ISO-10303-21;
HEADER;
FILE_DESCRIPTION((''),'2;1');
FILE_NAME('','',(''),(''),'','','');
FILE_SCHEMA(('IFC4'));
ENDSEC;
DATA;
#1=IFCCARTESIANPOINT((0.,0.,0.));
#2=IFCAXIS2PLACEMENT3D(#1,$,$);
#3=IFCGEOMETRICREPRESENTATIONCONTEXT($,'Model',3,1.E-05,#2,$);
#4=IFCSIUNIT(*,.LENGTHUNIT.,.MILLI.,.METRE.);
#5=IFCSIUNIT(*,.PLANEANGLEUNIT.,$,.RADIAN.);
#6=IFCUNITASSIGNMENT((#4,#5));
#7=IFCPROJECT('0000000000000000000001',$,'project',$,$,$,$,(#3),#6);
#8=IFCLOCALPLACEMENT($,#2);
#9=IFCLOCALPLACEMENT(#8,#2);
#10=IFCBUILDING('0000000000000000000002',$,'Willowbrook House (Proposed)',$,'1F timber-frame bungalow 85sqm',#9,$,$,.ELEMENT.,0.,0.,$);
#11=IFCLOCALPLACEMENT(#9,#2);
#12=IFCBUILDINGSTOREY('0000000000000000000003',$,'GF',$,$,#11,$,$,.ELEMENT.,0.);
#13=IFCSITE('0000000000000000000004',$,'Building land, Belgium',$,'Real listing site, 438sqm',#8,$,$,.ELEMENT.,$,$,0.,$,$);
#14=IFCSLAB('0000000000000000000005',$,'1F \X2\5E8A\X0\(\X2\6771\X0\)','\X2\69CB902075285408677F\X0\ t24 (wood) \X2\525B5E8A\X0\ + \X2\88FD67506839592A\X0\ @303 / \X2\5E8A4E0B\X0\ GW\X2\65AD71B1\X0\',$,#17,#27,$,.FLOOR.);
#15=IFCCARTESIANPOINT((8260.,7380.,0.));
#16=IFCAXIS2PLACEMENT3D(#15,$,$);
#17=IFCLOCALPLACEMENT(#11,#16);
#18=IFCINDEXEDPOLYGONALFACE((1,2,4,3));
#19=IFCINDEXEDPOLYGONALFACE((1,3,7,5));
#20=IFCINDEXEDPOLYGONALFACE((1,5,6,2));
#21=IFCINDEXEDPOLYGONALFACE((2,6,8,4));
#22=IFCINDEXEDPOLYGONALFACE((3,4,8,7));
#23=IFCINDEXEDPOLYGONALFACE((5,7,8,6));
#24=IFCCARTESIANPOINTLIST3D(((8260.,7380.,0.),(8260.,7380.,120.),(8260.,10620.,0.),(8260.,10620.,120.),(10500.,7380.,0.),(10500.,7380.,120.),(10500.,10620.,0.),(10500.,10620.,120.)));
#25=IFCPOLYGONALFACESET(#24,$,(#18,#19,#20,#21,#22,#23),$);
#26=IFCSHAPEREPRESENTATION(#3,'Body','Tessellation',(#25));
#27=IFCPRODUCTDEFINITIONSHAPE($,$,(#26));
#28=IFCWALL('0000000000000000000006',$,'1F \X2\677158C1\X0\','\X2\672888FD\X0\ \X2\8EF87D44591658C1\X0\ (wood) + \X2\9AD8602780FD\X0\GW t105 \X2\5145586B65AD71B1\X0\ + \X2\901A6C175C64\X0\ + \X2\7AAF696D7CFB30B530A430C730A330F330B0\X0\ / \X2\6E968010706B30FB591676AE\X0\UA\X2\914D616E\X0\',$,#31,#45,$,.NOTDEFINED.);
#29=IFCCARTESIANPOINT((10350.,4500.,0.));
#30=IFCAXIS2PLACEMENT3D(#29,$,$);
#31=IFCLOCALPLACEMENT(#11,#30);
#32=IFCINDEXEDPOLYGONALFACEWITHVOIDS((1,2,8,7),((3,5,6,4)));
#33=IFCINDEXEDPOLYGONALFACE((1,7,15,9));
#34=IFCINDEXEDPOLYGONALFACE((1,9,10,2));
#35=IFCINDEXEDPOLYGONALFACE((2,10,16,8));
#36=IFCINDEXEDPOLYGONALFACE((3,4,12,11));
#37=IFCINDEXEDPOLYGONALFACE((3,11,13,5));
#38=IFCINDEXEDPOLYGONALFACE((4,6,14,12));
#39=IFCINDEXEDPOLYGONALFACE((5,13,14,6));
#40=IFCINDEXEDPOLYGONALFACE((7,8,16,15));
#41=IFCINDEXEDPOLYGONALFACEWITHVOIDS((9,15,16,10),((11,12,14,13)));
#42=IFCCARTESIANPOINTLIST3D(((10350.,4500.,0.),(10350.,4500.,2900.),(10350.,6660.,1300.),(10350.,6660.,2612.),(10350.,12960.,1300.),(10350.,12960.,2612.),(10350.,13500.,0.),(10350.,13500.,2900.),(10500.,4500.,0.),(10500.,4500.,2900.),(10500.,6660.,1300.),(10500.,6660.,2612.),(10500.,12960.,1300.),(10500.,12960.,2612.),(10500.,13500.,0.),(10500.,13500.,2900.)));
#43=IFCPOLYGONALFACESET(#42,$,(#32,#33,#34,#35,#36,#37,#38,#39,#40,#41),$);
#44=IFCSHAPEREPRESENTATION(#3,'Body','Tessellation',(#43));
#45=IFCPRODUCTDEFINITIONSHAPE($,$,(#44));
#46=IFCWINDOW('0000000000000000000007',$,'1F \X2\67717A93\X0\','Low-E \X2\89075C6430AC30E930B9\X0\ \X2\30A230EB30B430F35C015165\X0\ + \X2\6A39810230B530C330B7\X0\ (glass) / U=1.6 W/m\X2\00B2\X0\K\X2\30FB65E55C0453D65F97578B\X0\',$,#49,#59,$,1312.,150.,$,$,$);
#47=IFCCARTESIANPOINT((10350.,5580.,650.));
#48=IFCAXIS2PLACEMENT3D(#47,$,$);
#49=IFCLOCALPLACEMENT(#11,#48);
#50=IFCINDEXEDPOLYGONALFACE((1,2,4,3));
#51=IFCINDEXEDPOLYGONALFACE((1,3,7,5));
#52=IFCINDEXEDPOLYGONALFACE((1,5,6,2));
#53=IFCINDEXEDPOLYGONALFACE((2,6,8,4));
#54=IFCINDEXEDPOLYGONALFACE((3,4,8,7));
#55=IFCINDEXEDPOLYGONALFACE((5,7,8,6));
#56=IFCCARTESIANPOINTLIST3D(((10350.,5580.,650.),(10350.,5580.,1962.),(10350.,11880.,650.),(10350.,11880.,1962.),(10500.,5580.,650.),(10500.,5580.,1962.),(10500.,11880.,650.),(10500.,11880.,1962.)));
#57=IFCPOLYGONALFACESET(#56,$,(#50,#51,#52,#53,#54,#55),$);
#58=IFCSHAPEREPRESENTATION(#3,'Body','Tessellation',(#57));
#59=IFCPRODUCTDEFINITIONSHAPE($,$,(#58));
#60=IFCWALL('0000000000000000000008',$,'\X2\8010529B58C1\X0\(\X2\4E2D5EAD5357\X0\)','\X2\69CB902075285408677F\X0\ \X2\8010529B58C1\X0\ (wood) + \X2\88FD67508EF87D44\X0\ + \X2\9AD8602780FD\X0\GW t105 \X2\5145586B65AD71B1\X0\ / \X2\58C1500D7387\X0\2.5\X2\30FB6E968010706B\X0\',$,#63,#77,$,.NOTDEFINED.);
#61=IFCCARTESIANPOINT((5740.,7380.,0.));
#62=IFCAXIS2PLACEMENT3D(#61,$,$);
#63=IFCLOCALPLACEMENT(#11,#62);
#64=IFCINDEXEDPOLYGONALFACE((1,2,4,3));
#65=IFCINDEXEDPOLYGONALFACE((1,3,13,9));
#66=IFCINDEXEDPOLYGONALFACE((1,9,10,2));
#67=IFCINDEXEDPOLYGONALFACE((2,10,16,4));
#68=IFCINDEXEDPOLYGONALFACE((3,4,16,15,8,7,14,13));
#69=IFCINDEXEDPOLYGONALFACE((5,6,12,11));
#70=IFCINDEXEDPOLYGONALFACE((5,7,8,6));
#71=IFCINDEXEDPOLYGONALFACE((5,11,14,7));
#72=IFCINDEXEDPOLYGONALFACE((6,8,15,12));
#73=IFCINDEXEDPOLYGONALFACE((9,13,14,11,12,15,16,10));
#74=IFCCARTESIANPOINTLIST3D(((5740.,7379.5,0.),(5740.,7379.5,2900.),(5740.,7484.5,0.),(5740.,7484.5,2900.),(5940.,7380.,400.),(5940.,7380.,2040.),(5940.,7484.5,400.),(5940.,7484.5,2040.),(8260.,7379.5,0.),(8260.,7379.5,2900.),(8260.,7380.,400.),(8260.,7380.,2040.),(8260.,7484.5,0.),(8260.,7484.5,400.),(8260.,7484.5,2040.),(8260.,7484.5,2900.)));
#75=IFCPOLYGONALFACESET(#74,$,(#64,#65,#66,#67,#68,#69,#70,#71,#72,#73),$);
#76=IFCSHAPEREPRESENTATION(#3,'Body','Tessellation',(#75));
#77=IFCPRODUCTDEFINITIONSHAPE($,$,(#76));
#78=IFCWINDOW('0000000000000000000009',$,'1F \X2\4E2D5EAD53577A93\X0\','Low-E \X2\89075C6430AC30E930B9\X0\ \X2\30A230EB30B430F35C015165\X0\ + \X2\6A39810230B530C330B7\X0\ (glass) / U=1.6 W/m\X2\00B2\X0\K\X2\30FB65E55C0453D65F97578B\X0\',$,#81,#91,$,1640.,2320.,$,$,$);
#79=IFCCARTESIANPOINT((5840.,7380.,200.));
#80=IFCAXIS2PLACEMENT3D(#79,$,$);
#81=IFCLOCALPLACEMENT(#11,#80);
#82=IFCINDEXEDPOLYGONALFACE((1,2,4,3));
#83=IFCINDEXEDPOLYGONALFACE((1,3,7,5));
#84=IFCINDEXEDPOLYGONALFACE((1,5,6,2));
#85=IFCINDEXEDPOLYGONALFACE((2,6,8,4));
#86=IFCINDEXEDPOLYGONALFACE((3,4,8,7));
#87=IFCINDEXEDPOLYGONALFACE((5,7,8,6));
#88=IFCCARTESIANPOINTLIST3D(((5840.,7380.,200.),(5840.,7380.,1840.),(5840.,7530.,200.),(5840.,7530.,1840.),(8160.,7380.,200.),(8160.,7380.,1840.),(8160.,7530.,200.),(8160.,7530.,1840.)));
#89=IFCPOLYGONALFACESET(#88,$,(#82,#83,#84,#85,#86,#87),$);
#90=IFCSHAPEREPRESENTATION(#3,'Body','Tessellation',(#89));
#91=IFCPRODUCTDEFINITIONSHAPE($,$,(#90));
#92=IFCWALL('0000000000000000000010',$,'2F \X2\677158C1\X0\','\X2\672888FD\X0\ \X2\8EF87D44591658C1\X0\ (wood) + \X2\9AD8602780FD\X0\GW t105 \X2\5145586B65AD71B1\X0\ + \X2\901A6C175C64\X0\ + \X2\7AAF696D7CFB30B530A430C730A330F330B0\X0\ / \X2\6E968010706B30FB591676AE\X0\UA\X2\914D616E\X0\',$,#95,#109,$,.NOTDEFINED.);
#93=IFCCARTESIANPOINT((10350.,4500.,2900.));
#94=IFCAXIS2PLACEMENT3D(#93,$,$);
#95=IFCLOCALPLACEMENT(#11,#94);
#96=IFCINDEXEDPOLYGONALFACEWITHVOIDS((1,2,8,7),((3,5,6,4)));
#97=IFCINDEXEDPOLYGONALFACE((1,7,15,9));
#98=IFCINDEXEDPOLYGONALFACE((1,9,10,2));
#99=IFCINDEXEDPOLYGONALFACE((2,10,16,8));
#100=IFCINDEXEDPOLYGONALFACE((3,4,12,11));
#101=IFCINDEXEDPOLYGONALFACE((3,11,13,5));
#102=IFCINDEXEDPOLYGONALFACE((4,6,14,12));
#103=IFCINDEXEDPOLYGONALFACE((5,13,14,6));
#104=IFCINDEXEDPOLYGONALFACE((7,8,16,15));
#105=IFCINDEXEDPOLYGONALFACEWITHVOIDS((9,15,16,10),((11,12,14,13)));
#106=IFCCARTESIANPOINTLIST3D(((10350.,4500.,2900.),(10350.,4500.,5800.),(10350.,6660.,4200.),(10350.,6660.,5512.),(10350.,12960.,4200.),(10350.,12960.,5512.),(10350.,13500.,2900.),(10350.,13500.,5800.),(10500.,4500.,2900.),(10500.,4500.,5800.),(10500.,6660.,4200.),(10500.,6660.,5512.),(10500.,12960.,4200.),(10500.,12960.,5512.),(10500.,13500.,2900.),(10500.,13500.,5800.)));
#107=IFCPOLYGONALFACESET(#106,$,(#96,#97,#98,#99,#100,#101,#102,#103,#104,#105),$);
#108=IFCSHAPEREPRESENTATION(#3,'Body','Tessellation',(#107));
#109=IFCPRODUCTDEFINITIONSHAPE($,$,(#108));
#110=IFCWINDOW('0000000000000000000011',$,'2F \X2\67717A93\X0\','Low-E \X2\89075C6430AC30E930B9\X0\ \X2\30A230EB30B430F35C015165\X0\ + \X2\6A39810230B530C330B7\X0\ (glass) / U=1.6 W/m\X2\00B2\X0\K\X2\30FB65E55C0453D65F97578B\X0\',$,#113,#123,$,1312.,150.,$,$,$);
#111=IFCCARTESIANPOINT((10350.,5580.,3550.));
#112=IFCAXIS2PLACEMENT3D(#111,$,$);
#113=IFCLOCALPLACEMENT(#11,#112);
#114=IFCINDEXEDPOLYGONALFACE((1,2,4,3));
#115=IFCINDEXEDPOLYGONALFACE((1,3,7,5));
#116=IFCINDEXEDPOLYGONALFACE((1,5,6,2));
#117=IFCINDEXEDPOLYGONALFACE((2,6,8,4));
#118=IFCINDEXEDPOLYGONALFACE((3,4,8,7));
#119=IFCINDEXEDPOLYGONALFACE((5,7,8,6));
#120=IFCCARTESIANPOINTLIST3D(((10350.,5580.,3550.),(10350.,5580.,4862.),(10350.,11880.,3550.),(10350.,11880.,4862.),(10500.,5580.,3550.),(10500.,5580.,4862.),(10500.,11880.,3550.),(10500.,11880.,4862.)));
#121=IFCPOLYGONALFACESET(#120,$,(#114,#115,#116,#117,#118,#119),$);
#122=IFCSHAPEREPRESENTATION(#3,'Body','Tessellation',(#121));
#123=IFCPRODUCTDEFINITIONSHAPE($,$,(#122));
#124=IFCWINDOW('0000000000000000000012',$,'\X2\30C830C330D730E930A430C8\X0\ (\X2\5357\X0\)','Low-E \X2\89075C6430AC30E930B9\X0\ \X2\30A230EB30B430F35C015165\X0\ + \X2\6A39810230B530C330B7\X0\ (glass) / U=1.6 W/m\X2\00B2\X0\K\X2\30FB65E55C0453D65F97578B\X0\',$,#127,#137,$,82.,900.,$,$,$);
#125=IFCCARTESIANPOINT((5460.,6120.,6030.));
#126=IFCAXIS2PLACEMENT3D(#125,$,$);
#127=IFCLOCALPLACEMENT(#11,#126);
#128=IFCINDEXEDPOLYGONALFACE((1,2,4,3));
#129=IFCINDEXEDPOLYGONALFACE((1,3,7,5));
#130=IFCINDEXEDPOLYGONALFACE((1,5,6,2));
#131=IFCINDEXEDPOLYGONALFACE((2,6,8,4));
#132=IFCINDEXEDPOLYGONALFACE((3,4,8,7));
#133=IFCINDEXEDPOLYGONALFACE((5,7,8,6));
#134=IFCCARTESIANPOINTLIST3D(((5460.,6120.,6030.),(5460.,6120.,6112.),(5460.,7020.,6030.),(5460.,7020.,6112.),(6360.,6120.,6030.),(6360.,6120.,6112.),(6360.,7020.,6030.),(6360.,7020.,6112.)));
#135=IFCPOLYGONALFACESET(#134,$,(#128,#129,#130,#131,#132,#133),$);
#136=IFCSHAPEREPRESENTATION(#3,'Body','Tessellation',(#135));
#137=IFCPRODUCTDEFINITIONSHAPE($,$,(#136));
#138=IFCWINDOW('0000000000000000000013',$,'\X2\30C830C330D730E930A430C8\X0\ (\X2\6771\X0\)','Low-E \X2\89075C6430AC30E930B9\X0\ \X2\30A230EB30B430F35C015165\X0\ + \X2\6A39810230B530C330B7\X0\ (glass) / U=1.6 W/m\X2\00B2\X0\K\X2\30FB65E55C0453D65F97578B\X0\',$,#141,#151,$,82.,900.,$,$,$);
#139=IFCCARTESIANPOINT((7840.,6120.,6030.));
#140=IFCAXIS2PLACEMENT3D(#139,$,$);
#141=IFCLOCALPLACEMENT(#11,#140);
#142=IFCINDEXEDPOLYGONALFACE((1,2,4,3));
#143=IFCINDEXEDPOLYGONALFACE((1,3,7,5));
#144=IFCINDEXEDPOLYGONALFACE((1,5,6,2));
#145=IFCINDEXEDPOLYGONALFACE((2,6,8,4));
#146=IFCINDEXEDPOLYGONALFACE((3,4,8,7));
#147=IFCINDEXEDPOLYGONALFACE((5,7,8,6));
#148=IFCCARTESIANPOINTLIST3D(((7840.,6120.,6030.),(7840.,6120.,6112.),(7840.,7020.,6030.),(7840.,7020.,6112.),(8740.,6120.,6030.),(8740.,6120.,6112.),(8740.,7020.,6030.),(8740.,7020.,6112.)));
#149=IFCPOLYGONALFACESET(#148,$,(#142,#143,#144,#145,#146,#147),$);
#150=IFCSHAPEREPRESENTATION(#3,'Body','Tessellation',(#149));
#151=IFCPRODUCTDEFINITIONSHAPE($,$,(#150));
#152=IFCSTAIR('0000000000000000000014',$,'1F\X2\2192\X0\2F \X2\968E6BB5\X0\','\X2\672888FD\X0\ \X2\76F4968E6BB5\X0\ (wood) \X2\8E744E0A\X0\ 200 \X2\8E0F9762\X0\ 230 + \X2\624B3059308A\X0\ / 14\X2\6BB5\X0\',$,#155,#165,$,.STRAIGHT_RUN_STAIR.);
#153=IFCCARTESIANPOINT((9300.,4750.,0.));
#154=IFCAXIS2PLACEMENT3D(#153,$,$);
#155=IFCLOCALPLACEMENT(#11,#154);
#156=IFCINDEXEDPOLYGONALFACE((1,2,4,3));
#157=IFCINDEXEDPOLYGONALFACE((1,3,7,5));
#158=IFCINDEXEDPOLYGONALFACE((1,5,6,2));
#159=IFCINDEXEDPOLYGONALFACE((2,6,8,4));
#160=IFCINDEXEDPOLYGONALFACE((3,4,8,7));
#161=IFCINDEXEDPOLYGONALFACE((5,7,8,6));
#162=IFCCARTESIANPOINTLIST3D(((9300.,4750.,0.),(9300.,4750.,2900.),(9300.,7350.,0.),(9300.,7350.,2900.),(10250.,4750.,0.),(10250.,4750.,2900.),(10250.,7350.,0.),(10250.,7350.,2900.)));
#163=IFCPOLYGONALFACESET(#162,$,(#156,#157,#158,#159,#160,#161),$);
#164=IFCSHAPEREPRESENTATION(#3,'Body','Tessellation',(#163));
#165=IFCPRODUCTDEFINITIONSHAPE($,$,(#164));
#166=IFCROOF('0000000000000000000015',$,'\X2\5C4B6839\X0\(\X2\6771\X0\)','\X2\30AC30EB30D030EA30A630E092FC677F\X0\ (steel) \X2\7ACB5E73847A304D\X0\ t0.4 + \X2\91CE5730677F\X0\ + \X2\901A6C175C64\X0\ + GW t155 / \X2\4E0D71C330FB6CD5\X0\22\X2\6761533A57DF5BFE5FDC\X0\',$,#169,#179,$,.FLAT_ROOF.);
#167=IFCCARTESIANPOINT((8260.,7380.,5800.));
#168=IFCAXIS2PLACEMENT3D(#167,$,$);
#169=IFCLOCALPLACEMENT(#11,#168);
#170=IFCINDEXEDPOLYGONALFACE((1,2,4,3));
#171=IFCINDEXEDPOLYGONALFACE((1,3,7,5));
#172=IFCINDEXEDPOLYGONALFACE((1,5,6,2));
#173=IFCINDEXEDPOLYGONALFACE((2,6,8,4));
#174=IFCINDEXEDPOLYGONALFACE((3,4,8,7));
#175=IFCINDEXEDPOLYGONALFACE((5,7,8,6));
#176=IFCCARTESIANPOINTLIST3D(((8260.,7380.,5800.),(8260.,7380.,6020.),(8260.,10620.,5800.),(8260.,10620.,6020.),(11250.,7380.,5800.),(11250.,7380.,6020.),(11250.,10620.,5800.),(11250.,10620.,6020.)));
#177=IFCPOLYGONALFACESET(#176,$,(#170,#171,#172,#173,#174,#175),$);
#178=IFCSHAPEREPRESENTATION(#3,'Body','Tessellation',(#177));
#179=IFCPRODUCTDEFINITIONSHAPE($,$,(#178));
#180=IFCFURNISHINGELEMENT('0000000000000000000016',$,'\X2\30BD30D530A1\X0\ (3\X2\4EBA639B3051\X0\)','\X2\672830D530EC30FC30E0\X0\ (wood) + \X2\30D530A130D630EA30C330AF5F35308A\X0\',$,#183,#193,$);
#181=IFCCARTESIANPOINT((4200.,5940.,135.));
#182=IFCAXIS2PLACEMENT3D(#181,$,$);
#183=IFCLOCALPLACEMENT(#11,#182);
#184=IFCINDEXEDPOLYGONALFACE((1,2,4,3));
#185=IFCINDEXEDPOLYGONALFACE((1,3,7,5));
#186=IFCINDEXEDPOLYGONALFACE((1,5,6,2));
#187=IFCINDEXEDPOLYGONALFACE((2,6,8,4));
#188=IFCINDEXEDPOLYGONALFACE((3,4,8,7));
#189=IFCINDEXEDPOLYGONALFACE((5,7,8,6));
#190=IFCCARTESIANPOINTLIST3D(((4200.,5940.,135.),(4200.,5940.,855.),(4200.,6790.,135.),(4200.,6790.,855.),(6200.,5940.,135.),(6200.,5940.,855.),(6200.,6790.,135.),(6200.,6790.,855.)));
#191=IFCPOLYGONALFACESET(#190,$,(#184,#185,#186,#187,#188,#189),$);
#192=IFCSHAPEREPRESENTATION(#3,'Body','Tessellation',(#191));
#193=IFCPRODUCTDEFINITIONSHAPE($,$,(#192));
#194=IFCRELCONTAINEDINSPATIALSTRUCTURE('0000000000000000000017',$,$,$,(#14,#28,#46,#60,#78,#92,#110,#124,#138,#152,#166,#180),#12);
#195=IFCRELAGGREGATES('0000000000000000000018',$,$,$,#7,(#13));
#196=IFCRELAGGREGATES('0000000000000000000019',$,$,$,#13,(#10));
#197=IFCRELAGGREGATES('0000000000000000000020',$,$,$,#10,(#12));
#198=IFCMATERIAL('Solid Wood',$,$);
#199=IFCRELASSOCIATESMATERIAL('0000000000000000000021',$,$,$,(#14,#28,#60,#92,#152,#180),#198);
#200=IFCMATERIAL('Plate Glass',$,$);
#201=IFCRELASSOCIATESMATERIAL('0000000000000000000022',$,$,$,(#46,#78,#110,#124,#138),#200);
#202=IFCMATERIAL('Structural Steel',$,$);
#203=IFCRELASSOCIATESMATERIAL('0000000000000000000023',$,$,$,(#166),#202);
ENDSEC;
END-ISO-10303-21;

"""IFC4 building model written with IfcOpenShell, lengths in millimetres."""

from ifc_helpers import new_model, si_unit, frame, frame_2d, origin, place, context, project, spatial, rectangle, extrude, material, element, fill, save


model = new_model("IFC4")

# Units and contexts
model_context = context("Model", 3, precision=1e-05, world=origin())
ifc_project = project(units=[si_unit("LENGTHUNIT", "METRE", prefix="MILLI"), si_unit("PLANEANGLEUNIT", "RADIAN")], contexts=[model_context])

# Site, building, storey
site_placement = place(None, origin())
site = spatial("IfcSite", under=ifc_project, at=site_placement, Name="Building land, Belgium", ObjectType="Real listing site, 438sqm", CompositionType="ELEMENT", RefElevation=0.0)
building_placement = place(site_placement, origin())
building = spatial("IfcBuilding", under=site, at=building_placement, Name="Willowbrook House (Proposed)", ObjectType="1F timber-frame bungalow 85sqm", CompositionType="ELEMENT", ElevationOfRefHeight=0.0, ElevationOfTerrain=0.0)
storey_placement = place(building_placement, origin())
storey = spatial("IfcBuildingStorey", under=building, at=storey_placement, Name="GF", CompositionType="ELEMENT", Elevation=0.0)

# Slab
ifc_material_1 = material(Name="Solid Wood")
slab_placement = place(storey_placement, frame((8260.0, 7380.0, 0.0)))
element("IfcSlab", 1, at=slab_placement, inside=storey, material=ifc_material_1, Name="1F 床(東)", Description="構造用合板 t24 (wood) 剛床 + 製材根太 @303 / 床下 GW断熱", PredefinedType="FLOOR", context=model_context, shape_type="SweptSolid", body=[
    extrude(rectangle(XDim=2240.0, YDim=3240.0, at=frame_2d((1120.0, 1620.0))), frame((8260.0, 7380.0, 0.0)), (0.0, 0.0, 1.0), 120.0),
])

# Walls, openings, windows
wall_1_placement = place(storey_placement, frame((10350.0, 4500.0, 0.0)))
wall_1 = element("IfcWall", 2, at=wall_1_placement, inside=storey, material=ifc_material_1, Name="1F 東壁", Description="木製 軸組外壁 (wood) + 高性能GW t105 充填断熱 + 通気層 + 窯業系サイディング / 準耐火・外皮UA配慮", PredefinedType="NOTDEFINED", context=model_context, shape_type="SweptSolid", body=[
    extrude(rectangle(XDim=150.0, YDim=9000.0, at=frame_2d((75.0, 4500.0))), frame((10350.0, 4500.0, 0.0)), (0.0, 0.0, 1.0), 2900.0),
])
opening_1_placement = place(storey_placement, frame((10350.0, 5580.0, 650.0)))
opening_1 = element("IfcOpeningElement", 3, at=opening_1_placement, cuts=wall_1, PredefinedType="NOTDEFINED", context=model_context, shape_type="SweptSolid", body=[
    extrude(rectangle(XDim=150.0, YDim=6300.0, at=frame_2d((75.0, 3150.0))), frame((10350.0, 5580.0, 650.0)), (0.0, 0.0, 1.0), 1312.0),
])
ifc_material_2 = material(Name="Plate Glass")
window_1_placement = place(storey_placement, frame((10350.0, 5580.0, 650.0)))
window_1 = element("IfcWindow", 4, at=window_1_placement, inside=storey, material=ifc_material_2, Name="1F 東窓", Description="Low-E 複層ガラス アルゴン封入 + 樹脂サッシ (glass) / U=1.6 W/m²K・日射取得型", OverallHeight=1312.0, OverallWidth=150.0, context=model_context, shape_type="SweptSolid", body=[
    extrude(rectangle(XDim=150.0, YDim=6300.0, at=frame_2d((75.0, 3150.0))), frame((10350.0, 5580.0, 650.0)), (0.0, 0.0, 1.0), 1312.0),
])
fill(opening_1, window_1)
wall_2_placement = place(storey_placement, frame((5740.0, 7380.0, 0.0)))
wall_2 = element("IfcWall", 5, at=wall_2_placement, inside=storey, material=ifc_material_1, Name="耐力壁(中庭南)", Description="構造用合板 耐力壁 (wood) + 製材軸組 + 高性能GW t105 充填断熱 / 壁倍率2.5・準耐火", PredefinedType="NOTDEFINED", context=model_context, shape_type="SweptSolid", body=[
    extrude(rectangle(XDim=2520.0, YDim=105.0, at=frame_2d((1260.0, 52.0))), frame((5740.0, 7380.0, 0.0)), (0.0, 0.0, 1.0), 2900.0),
])
opening_2_placement = place(storey_placement, frame((5840.0, 7380.0, 200.0)))
opening_2 = element("IfcOpeningElement", 6, at=opening_2_placement, cuts=wall_2, PredefinedType="NOTDEFINED", context=model_context, shape_type="SweptSolid", body=[
    extrude(rectangle(XDim=2320.0, YDim=150.0, at=frame_2d((1160.0, 75.0))), frame((5840.0, 7380.0, 200.0)), (0.0, 0.0, 1.0), 1640.0),
])
window_2_placement = place(storey_placement, frame((5840.0, 7380.0, 200.0)))
window_2 = element("IfcWindow", 7, at=window_2_placement, inside=storey, material=ifc_material_2, Name="1F 中庭南窓", Description="Low-E 複層ガラス アルゴン封入 + 樹脂サッシ (glass) / U=1.6 W/m²K・日射取得型", OverallHeight=1640.0, OverallWidth=2320.0, context=model_context, shape_type="SweptSolid", body=[
    extrude(rectangle(XDim=2320.0, YDim=150.0, at=frame_2d((1160.0, 75.0))), frame((5840.0, 7380.0, 200.0)), (0.0, 0.0, 1.0), 1640.0),
])
fill(opening_2, window_2)

# Wall, opening, window
wall_3_placement = place(storey_placement, frame((10350.0, 4500.0, 2900.0)))
wall_3 = element("IfcWall", 8, at=wall_3_placement, inside=storey, material=ifc_material_1, Name="2F 東壁", Description="木製 軸組外壁 (wood) + 高性能GW t105 充填断熱 + 通気層 + 窯業系サイディング / 準耐火・外皮UA配慮", PredefinedType="NOTDEFINED", context=model_context, shape_type="SweptSolid", body=[
    extrude(rectangle(XDim=150.0, YDim=9000.0, at=frame_2d((75.0, 4500.0))), frame((10350.0, 4500.0, 2900.0)), (0.0, 0.0, 1.0), 2900.0),
])
opening_3_placement = place(storey_placement, frame((10350.0, 5580.0, 3550.0)))
opening_3 = element("IfcOpeningElement", 9, at=opening_3_placement, cuts=wall_3, PredefinedType="NOTDEFINED", context=model_context, shape_type="SweptSolid", body=[
    extrude(rectangle(XDim=150.0, YDim=6300.0, at=frame_2d((75.0, 3150.0))), frame((10350.0, 5580.0, 3550.0)), (0.0, 0.0, 1.0), 1312.0),
])
window_3_placement = place(storey_placement, frame((10350.0, 5580.0, 3550.0)))
window_3 = element("IfcWindow", 10, at=window_3_placement, inside=storey, material=ifc_material_2, Name="2F 東窓", Description="Low-E 複層ガラス アルゴン封入 + 樹脂サッシ (glass) / U=1.6 W/m²K・日射取得型", OverallHeight=1312.0, OverallWidth=150.0, context=model_context, shape_type="SweptSolid", body=[
    extrude(rectangle(XDim=150.0, YDim=6300.0, at=frame_2d((75.0, 3150.0))), frame((10350.0, 5580.0, 3550.0)), (0.0, 0.0, 1.0), 1312.0),
])
fill(opening_3, window_3)

# Windows
window_4_placement = place(storey_placement, frame((5460.0, 6120.0, 6030.0)))
element("IfcWindow", 11, at=window_4_placement, inside=storey, material=ifc_material_2, Name="トップライト (南)", Description="Low-E 複層ガラス アルゴン封入 + 樹脂サッシ (glass) / U=1.6 W/m²K・日射取得型", OverallHeight=82.0, OverallWidth=900.0, context=model_context, shape_type="SweptSolid", body=[
    extrude(rectangle(XDim=900.0, YDim=900.0, at=frame_2d((450.0, 450.0))), frame((5460.0, 6120.0, 6030.0)), (0.0, 0.0, 1.0), 82.0),
])
window_5_placement = place(storey_placement, frame((7840.0, 6120.0, 6030.0)))
element("IfcWindow", 12, at=window_5_placement, inside=storey, material=ifc_material_2, Name="トップライト (東)", Description="Low-E 複層ガラス アルゴン封入 + 樹脂サッシ (glass) / U=1.6 W/m²K・日射取得型", OverallHeight=82.0, OverallWidth=900.0, context=model_context, shape_type="SweptSolid", body=[
    extrude(rectangle(XDim=900.0, YDim=900.0, at=frame_2d((450.0, 450.0))), frame((7840.0, 6120.0, 6030.0)), (0.0, 0.0, 1.0), 82.0),
])

# Stair
stair_placement = place(storey_placement, frame((9300.0, 4750.0, 0.0)))
element("IfcStair", 13, at=stair_placement, inside=storey, material=ifc_material_1, Name="1F→2F 階段", Description="木製 直階段 (wood) 蹴上 200 踏面 230 + 手すり / 14段", PredefinedType="STRAIGHT_RUN_STAIR", context=model_context, shape_type="SweptSolid", body=[
    extrude(rectangle(XDim=950.0, YDim=2600.0, at=frame_2d((475.0, 1300.0))), frame((9300.0, 4750.0, 0.0)), (0.0, 0.0, 1.0), 2900.0),
])

# Roof
ifc_material_3 = material(Name="Structural Steel")
roof_placement = place(storey_placement, frame((8260.0, 7380.0, 5800.0)))
element("IfcRoof", 14, at=roof_placement, inside=storey, material=ifc_material_3, Name="屋根(東)", Description="ガルバリウム鋼板 (steel) 立平葺き t0.4 + 野地板 + 通気層 + GW t155 / 不燃・法22条区域対応", PredefinedType="FLAT_ROOF", context=model_context, shape_type="SweptSolid", body=[
    extrude(rectangle(XDim=2990.0, YDim=3240.0, at=frame_2d((1495.0, 1620.0))), frame((8260.0, 7380.0, 5800.0)), (0.0, 0.0, 1.0), 220.0),
])

# Furnishing element
furnishing_1_placement = place(storey_placement, frame((4200.0, 5940.0, 135.0)))
element("IfcFurnishingElement", 15, at=furnishing_1_placement, inside=storey, material=ifc_material_1, Name="ソファ (3人掛け)", Description="木フレーム (wood) + ファブリック張り", context=model_context, shape_type="SweptSolid", body=[
    extrude(rectangle(XDim=2000.0, YDim=850.0, at=frame_2d((1000.0, 425.0))), frame((4200.0, 5940.0, 135.0)), (0.0, 0.0, 1.0), 720.0),
])

save(model, "model.ifc")
